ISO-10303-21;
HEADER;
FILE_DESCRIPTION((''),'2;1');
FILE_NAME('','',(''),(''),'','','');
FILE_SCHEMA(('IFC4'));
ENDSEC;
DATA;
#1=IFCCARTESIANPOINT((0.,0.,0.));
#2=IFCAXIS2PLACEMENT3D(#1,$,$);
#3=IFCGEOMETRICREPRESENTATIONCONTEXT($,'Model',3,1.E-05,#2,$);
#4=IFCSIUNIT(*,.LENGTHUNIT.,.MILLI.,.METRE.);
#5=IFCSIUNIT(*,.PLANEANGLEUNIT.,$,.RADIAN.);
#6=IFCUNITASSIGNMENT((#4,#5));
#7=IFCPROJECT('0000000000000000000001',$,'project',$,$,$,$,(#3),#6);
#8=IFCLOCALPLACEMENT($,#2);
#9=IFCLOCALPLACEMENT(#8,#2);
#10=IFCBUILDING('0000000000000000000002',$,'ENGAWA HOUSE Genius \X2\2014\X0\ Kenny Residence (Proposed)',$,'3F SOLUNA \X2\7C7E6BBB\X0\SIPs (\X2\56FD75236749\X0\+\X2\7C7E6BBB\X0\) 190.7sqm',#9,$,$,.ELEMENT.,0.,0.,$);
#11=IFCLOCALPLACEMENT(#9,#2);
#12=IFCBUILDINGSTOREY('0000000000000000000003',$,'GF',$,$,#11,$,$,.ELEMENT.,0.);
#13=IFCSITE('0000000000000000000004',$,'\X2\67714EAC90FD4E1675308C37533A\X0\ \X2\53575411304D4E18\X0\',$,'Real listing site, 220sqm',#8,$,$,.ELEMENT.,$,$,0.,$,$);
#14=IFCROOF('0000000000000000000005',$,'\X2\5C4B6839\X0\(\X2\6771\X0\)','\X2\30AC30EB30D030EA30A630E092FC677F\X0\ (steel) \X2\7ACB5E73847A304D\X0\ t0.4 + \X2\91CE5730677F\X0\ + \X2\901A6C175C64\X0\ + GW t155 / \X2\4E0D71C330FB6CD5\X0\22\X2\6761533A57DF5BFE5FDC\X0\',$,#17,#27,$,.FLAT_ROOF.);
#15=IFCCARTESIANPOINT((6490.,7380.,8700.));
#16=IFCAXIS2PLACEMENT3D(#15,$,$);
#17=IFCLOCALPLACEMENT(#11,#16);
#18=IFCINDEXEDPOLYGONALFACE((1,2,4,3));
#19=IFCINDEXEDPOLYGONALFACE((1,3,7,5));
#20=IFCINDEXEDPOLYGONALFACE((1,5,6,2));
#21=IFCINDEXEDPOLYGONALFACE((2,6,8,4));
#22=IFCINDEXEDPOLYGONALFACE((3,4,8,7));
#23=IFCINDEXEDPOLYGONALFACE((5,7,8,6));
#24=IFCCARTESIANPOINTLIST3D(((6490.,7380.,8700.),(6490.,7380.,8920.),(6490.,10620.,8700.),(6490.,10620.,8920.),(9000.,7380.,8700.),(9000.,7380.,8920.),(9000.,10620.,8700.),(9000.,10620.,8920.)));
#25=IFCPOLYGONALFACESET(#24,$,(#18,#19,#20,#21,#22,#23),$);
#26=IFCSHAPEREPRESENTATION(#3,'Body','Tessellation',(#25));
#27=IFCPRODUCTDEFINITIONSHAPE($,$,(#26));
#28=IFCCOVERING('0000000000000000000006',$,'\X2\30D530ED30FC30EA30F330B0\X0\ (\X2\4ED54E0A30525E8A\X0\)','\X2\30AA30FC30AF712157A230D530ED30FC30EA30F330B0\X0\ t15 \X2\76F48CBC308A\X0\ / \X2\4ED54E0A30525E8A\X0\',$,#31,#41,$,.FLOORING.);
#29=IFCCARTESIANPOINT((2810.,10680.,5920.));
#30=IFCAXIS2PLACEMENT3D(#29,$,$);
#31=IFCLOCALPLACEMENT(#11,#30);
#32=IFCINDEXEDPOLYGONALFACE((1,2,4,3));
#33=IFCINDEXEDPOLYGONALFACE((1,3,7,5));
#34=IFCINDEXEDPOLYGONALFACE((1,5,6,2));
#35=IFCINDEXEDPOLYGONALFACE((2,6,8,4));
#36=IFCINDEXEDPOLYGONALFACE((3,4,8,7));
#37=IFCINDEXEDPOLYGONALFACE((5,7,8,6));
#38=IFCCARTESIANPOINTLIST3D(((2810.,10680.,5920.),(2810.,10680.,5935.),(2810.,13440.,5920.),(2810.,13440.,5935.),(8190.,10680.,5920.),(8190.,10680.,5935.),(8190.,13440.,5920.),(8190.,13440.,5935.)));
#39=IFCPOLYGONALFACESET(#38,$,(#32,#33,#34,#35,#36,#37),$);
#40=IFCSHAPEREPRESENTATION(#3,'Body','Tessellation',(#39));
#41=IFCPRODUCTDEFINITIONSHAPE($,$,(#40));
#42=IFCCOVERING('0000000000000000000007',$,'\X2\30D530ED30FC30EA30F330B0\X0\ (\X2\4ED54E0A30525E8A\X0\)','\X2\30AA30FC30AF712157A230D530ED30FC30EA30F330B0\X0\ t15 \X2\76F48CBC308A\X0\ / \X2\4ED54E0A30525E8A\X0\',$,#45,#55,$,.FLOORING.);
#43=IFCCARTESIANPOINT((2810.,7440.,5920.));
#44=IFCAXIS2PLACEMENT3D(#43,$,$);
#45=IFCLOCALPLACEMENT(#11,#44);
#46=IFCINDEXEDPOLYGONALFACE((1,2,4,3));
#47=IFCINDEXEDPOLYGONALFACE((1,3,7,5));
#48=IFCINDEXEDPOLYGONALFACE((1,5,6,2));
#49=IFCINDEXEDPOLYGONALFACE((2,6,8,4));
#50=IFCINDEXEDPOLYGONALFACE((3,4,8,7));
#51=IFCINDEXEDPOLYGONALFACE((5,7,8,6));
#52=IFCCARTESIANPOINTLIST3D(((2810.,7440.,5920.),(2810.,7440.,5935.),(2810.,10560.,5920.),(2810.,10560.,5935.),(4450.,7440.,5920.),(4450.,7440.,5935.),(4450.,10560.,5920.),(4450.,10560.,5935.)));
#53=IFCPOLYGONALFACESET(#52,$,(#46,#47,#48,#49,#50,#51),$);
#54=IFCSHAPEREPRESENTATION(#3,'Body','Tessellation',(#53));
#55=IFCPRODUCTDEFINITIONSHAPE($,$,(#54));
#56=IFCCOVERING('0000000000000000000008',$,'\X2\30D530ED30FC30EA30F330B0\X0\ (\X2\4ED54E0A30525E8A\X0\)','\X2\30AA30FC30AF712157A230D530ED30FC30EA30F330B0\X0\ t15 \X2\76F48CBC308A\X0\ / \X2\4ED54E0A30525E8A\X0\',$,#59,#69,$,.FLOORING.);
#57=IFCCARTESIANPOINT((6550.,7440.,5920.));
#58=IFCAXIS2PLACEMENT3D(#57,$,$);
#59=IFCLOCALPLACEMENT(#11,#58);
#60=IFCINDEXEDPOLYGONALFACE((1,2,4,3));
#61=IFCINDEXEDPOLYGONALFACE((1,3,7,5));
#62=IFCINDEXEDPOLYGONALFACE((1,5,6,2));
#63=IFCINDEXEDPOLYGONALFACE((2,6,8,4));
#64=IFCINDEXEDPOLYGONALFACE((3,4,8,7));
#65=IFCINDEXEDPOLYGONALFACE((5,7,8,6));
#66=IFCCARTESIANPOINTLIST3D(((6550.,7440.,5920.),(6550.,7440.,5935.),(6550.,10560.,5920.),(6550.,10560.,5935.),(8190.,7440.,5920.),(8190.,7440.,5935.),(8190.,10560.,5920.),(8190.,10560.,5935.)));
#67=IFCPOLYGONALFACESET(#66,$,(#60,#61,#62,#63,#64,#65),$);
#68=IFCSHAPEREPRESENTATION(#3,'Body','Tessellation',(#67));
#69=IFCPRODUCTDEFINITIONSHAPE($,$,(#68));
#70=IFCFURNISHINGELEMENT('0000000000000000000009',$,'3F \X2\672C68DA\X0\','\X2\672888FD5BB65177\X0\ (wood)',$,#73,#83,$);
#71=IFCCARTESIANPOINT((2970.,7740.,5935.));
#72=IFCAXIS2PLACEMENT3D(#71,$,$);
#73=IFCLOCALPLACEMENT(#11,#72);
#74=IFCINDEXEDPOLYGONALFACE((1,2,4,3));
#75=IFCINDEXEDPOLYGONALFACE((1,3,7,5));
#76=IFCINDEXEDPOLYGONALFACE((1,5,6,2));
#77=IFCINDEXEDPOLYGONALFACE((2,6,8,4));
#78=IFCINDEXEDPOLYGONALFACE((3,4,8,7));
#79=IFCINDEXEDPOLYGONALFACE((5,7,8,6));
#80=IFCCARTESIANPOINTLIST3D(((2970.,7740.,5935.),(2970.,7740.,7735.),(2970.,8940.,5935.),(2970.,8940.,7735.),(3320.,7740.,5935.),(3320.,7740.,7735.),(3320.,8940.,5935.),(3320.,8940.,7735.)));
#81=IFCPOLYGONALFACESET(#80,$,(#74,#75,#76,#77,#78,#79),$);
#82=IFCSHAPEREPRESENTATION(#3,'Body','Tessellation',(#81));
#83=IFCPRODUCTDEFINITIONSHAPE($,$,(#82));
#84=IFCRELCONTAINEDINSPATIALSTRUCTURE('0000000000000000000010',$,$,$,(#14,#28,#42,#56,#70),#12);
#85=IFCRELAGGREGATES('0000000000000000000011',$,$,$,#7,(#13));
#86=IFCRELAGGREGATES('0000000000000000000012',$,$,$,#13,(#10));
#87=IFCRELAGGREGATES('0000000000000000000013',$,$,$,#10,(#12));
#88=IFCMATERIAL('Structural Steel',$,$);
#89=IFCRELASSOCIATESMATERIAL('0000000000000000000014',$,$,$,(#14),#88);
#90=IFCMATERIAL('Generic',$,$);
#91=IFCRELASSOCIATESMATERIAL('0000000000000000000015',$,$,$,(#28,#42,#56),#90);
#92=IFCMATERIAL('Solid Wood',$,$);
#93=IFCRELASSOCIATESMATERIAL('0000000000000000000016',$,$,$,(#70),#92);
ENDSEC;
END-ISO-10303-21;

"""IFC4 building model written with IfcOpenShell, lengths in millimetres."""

from ifc_helpers import new_model, si_unit, frame, frame_2d, origin, place, context, project, spatial, rectangle, extrude, material, element, save


model = new_model("IFC4")

# Units and contexts
model_context = context("Model", 3, precision=1e-05, world=origin())
ifc_project = project(units=[si_unit("LENGTHUNIT", "METRE", prefix="MILLI"), si_unit("PLANEANGLEUNIT", "RADIAN")], contexts=[model_context])

# Site, building, storey
site_placement = place(None, origin())
site = spatial("IfcSite", under=ifc_project, at=site_placement, Name="東京都世田谷区 南向き丘", ObjectType="Real listing site, 220sqm", CompositionType="ELEMENT", RefElevation=0.0)
building_placement = place(site_placement, origin())
building = spatial("IfcBuilding", under=site, at=building_placement, Name="ENGAWA HOUSE Genius — Kenny Residence (Proposed)", ObjectType="3F SOLUNA 籾殻SIPs (国産杉+籾殻) 190.7sqm", CompositionType="ELEMENT", ElevationOfRefHeight=0.0, ElevationOfTerrain=0.0)
storey_placement = place(building_placement, origin())
storey = spatial("IfcBuildingStorey", under=building, at=storey_placement, Name="GF", CompositionType="ELEMENT", Elevation=0.0)

# Shared definitions
ifc_material_1 = material(Name="Solid Wood")

# Shared definitions
ifc_material_2 = material(Name="Generic")

# Roof
ifc_material_3 = material(Name="Structural Steel")
roof_1_placement = place(storey_placement, frame((6490.0, 7380.0, 8700.0)))
element("IfcRoof", 1, at=roof_1_placement, inside=storey, material=ifc_material_3, Name="屋根(東)", Description="ガルバリウム鋼板 (steel) 立平葺き t0.4 + 野地板 + 通気層 + GW t155 / 不燃・法22条区域対応", PredefinedType="FLAT_ROOF", context=model_context, shape_type="SweptSolid", body=[
    extrude(rectangle(XDim=2510.0, YDim=3240.0, at=frame_2d((1255.0, 1620.0))), frame((6490.0, 7380.0, 8700.0)), (0.0, 0.0, 1.0), 220.0),
])

# Coverings
covering_1_placement = place(storey_placement, frame((2810.0, 10680.0, 5920.0)))
element("IfcCovering", 2, at=covering_1_placement, inside=storey, material=ifc_material_2, Name="フローリング (仕上げ床)", Description="オーク無垢フローリング t15 直貼り / 仕上げ床", PredefinedType="FLOORING", context=model_context, shape_type="SweptSolid", body=[
    extrude(rectangle(XDim=5380.0, YDim=2760.0, at=frame_2d((2690.0, 1380.0))), frame((2810.0, 10680.0, 5920.0)), (0.0, 0.0, 1.0), 15.0),
])
covering_2_placement = place(storey_placement, frame((2810.0, 7440.0, 5920.0)))
element("IfcCovering", 3, at=covering_2_placement, inside=storey, material=ifc_material_2, Name="フローリング (仕上げ床)", Description="オーク無垢フローリング t15 直貼り / 仕上げ床", PredefinedType="FLOORING", context=model_context, shape_type="SweptSolid", body=[
    extrude(rectangle(XDim=1640.0, YDim=3120.0, at=frame_2d((820.0, 1560.0))), frame((2810.0, 7440.0, 5920.0)), (0.0, 0.0, 1.0), 15.0),
])
covering_3_placement = place(storey_placement, frame((6550.0, 7440.0, 5920.0)))
element("IfcCovering", 4, at=covering_3_placement, inside=storey, material=ifc_material_2, Name="フローリング (仕上げ床)", Description="オーク無垢フローリング t15 直貼り / 仕上げ床", PredefinedType="FLOORING", context=model_context, shape_type="SweptSolid", body=[
    extrude(rectangle(XDim=1640.0, YDim=3120.0, at=frame_2d((820.0, 1560.0))), frame((6550.0, 7440.0, 5920.0)), (0.0, 0.0, 1.0), 15.0),
])

# Furnishing element
furnishing_placement = place(storey_placement, frame((2970.0, 7740.0, 5935.0)))
element("IfcFurnishingElement", 5, at=furnishing_placement, inside=storey, material=ifc_material_1, Name="3F 本棚", Description="木製家具 (wood)", context=model_context, shape_type="SweptSolid", body=[
    extrude(rectangle(XDim=350.0, YDim=1200.0, at=frame_2d((175.0, 600.0))), frame((2970.0, 7740.0, 5935.0)), (0.0, 0.0, 1.0), 1800.0),
])

save(model, "model.ifc")
